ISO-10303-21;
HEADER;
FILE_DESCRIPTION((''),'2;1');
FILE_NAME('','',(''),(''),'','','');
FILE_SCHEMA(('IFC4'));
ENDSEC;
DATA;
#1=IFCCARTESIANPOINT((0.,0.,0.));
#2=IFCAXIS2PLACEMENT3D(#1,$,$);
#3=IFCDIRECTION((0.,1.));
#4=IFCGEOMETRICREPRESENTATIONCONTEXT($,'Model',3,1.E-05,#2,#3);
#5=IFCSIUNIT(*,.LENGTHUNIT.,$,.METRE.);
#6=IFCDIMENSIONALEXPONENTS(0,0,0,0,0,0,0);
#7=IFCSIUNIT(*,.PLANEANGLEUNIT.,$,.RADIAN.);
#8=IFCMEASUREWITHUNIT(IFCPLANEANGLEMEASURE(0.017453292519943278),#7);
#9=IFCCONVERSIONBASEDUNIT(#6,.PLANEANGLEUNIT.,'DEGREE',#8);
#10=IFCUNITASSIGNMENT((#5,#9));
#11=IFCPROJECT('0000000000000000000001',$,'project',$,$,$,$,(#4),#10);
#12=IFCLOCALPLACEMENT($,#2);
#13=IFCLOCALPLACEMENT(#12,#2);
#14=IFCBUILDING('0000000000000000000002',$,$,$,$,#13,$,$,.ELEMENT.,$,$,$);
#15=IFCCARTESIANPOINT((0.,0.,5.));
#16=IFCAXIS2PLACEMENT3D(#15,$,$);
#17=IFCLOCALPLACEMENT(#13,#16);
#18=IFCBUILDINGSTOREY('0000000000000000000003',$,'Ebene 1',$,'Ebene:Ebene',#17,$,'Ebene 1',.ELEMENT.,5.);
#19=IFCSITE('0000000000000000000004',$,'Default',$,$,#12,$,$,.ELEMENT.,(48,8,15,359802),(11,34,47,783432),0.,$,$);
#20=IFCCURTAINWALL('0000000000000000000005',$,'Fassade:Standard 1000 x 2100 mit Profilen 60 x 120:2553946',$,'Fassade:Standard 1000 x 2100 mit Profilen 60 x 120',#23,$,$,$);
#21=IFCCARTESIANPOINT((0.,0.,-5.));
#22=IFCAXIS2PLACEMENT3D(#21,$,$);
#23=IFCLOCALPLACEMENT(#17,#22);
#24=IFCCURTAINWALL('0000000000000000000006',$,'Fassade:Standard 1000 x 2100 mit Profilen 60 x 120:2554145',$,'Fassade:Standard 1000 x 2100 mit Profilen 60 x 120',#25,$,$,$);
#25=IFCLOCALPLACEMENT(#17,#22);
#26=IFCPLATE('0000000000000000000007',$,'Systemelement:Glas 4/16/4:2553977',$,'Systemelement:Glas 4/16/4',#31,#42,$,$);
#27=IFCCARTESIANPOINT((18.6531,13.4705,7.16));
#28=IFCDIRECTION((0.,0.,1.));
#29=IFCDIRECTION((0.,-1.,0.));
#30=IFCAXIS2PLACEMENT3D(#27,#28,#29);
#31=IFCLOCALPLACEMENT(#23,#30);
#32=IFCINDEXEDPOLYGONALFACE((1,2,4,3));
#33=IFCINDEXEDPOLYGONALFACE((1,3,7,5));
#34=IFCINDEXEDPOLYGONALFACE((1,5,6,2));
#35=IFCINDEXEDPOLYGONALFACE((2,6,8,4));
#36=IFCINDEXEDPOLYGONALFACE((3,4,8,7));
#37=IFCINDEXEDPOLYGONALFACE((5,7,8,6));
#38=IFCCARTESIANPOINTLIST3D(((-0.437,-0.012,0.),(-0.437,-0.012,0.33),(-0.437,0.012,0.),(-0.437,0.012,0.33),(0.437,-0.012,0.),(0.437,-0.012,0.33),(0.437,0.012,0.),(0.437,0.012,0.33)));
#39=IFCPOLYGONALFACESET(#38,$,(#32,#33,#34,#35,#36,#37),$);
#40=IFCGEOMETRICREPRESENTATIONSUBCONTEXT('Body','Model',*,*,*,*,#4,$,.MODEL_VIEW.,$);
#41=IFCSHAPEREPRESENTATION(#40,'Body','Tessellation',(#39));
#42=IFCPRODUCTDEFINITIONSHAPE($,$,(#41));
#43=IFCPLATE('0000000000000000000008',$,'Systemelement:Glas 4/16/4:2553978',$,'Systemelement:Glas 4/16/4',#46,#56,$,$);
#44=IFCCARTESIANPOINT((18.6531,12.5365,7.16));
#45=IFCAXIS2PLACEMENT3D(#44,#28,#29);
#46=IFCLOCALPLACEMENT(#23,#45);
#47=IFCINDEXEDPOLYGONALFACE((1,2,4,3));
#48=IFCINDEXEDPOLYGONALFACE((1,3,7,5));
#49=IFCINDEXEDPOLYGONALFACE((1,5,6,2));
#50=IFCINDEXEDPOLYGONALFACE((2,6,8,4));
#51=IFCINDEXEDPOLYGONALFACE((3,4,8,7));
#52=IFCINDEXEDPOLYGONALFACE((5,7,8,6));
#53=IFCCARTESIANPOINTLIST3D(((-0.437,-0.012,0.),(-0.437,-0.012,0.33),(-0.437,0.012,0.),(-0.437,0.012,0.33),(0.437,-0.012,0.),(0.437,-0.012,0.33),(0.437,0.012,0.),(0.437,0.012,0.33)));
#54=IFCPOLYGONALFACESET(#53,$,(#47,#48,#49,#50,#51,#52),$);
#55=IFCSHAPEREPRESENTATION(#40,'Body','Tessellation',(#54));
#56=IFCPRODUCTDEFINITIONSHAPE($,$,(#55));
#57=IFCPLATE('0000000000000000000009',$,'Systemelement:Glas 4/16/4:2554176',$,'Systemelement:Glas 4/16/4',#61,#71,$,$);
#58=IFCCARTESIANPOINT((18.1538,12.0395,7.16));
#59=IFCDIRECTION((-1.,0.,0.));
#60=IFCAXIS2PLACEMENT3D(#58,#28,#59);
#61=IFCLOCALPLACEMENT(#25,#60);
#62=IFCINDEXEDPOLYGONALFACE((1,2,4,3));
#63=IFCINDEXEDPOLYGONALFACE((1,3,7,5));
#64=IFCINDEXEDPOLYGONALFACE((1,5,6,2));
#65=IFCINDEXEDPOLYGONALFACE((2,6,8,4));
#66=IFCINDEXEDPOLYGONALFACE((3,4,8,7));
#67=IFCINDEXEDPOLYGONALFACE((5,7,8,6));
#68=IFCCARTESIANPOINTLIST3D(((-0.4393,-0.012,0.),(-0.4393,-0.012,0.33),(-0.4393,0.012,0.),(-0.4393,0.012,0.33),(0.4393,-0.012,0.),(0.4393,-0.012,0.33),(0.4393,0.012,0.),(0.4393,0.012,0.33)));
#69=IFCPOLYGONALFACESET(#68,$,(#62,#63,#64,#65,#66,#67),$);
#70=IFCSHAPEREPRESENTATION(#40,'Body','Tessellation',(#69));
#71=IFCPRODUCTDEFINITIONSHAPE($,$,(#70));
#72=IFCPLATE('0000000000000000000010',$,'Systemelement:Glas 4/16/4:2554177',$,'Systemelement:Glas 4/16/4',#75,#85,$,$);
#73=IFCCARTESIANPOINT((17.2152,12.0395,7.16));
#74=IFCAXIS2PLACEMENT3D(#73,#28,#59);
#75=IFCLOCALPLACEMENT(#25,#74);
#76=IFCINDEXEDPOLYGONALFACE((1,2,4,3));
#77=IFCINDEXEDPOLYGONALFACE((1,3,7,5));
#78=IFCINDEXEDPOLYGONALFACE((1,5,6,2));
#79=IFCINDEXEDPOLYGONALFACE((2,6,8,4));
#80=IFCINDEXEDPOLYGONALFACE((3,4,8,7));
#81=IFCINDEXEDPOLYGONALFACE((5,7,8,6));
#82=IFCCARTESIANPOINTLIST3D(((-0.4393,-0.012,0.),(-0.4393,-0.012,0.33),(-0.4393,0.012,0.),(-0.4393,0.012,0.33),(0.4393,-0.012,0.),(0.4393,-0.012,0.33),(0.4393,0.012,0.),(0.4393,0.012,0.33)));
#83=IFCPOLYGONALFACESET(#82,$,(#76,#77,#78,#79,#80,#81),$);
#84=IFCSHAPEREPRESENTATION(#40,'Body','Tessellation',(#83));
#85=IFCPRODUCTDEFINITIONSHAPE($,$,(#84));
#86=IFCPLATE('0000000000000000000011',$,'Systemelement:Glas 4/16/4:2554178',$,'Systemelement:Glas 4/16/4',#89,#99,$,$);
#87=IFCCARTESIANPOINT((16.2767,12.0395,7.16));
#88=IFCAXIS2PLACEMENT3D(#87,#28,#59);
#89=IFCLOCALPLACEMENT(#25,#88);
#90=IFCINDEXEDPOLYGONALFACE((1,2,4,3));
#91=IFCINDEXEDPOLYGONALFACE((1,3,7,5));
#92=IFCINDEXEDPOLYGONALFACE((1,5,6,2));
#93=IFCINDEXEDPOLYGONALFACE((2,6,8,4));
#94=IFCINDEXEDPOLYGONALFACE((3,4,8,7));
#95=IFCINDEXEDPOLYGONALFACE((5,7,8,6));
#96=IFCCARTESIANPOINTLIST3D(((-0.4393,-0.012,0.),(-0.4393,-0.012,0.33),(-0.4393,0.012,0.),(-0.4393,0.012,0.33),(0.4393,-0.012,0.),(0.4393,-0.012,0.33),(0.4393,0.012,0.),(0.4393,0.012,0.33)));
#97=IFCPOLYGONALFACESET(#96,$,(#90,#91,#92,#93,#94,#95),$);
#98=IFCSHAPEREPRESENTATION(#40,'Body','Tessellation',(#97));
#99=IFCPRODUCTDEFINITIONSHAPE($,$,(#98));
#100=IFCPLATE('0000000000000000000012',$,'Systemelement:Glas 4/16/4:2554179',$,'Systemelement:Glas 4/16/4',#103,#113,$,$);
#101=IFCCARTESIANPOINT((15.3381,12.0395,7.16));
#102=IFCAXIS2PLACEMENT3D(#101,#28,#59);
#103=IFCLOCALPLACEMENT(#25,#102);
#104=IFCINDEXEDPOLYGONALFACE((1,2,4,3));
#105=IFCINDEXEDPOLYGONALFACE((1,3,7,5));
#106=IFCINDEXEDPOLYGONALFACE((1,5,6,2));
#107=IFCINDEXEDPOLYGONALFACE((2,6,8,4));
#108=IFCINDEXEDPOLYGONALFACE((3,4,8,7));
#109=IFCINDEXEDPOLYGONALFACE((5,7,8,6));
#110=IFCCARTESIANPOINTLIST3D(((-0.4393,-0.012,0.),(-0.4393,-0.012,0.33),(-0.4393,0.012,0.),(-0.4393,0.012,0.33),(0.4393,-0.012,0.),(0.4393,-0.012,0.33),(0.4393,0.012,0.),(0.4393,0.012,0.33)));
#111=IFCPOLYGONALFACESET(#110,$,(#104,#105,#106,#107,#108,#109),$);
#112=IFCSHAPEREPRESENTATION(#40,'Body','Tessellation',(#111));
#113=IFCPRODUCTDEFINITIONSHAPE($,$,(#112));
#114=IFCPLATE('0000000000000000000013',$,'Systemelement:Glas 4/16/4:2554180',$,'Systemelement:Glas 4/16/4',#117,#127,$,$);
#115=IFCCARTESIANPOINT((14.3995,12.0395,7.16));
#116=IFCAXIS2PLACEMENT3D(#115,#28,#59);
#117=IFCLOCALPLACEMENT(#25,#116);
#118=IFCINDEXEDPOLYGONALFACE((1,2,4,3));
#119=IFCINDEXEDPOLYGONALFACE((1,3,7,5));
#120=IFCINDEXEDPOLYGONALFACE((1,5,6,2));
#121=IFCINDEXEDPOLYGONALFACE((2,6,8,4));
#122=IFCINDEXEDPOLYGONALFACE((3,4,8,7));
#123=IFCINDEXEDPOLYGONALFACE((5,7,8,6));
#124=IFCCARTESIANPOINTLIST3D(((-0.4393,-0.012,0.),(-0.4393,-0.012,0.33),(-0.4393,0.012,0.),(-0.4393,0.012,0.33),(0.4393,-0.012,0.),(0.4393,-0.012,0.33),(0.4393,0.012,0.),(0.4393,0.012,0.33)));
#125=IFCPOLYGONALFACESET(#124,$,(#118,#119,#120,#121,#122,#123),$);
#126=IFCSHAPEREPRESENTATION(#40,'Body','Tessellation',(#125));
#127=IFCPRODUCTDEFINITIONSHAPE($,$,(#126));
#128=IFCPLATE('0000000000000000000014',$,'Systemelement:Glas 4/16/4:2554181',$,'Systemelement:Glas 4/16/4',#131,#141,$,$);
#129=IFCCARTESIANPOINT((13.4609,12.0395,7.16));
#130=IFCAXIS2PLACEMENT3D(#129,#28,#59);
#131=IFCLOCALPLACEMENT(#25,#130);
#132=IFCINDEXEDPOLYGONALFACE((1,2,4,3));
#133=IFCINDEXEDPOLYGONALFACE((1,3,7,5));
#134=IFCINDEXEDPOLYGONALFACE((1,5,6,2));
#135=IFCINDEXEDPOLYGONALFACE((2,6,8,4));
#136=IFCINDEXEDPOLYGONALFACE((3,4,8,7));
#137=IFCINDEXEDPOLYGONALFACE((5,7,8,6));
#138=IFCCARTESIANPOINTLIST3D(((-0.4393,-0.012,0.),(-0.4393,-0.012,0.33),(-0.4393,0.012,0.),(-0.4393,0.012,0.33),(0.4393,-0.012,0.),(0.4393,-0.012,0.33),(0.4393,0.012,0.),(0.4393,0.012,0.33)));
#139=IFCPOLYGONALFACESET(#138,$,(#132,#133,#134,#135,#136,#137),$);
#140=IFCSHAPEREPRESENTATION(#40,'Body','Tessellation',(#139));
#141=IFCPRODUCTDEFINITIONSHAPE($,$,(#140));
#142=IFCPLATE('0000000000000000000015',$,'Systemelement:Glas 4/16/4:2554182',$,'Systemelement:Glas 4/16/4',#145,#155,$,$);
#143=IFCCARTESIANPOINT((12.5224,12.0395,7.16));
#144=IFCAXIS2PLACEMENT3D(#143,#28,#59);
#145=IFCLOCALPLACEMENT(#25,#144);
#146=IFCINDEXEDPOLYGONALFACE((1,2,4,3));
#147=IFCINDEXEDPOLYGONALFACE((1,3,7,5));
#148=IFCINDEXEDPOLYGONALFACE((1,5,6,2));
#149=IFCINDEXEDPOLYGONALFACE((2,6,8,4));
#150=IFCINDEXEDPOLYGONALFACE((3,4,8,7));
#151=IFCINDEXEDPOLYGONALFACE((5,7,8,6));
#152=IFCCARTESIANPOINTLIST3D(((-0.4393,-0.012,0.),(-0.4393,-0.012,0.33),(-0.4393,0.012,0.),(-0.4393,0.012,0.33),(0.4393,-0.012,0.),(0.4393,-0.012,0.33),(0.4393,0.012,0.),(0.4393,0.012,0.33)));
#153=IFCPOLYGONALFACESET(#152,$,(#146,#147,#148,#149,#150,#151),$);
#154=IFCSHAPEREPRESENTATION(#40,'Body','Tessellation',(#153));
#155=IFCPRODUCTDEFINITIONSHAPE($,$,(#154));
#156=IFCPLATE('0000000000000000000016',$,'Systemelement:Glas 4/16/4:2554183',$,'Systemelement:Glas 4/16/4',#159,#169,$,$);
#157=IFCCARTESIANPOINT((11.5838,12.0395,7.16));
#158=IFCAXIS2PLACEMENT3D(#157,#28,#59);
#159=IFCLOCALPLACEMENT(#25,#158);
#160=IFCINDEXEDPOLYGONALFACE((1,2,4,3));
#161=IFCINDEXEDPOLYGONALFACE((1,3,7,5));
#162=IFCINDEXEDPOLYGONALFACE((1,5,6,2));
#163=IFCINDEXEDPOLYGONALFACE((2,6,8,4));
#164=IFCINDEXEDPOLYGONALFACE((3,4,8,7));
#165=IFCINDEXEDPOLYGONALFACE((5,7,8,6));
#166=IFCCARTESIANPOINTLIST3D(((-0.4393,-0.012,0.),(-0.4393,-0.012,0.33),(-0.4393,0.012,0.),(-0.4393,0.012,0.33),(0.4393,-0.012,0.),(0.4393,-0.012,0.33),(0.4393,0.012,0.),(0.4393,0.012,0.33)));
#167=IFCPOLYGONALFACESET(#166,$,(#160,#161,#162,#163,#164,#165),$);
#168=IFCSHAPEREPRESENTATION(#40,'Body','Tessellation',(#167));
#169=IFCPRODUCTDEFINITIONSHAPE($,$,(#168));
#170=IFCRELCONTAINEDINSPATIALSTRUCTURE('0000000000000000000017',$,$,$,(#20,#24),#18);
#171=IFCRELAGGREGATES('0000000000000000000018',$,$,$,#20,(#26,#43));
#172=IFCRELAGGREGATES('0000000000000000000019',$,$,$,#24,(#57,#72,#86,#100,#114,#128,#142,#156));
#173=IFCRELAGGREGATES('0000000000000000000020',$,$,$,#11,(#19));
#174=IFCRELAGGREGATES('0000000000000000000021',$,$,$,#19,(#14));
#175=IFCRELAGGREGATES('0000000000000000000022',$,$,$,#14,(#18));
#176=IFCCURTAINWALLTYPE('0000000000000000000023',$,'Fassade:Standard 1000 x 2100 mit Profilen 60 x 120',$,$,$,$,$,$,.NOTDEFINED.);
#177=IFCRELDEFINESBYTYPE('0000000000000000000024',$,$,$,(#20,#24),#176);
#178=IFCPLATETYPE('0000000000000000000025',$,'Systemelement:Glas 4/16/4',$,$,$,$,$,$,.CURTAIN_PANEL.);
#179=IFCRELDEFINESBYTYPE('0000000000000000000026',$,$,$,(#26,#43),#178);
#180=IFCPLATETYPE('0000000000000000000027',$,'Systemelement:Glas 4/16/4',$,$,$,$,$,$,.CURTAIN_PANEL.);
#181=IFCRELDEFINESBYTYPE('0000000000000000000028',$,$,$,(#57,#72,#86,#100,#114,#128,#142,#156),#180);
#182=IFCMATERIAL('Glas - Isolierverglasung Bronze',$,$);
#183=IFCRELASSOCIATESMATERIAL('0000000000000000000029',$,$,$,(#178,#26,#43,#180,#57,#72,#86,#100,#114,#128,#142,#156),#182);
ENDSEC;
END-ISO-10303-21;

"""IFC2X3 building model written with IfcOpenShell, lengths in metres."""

from ifc_helpers import new_model, entity, si_unit, converted_unit, direction, frame, origin, origin_2d_with_axis, place, context, subcontext, project, spatial, rectangle, extrude, source, transform, mapped, material, type_object, type_shapes, element, aggregate, save


model = new_model("IFC2X3")

# Units and contexts
model_context = context("Model", 3, precision=1e-05, world=origin(), true_north=direction((0.0, 1.0)))
body_context = subcontext(model_context, "Body", "Model", "MODEL_VIEW")
ifc_project = project(units=[si_unit("LENGTHUNIT", "METRE"), converted_unit("PLANEANGLEUNIT", "DEGREE", entity("IfcPlaneAngleMeasure", 0.017453292519943278), si_unit("PLANEANGLEUNIT", "RADIAN"), dimensions=[0, 0, 0, 0, 0, 0, 0])], contexts=[model_context])

# Site, building, storey
site_placement = place(None, origin())
site = spatial("IfcSite", under=ifc_project, at=site_placement, Name="Default", CompositionType="ELEMENT", RefLatitude=(48, 8, 15, 359802), RefLongitude=(11, 34, 47, 783432), RefElevation=0.0)
building_placement = place(site_placement, origin())
building = spatial("IfcBuilding", under=site, at=building_placement, CompositionType="ELEMENT")
storey_placement = place(building_placement, frame((0.0, 0.0, 5.0)))
storey = spatial("IfcBuildingStorey", under=building, at=storey_placement, Name="Ebene 1", ObjectType="Ebene:Ebene", LongName="Ebene 1", CompositionType="ELEMENT", Elevation=5.0)

# Curtain wall
curtain_wall_type = type_object("IfcCurtainWallType", Name="Fassade:Standard 1000 x 2100 mit Profilen 60 x 120", PredefinedType="NOTDEFINED")
curtain_wall_1_placement = place(storey_placement, frame((0.0, 0.0, -5.0)))
curtain_wall_1 = element("IfcCurtainWall", 1, at=curtain_wall_1_placement, inside=storey, type_object=curtain_wall_type, Name="Fassade:Standard 1000 x 2100 mit Profilen 60 x 120:2553946", ObjectType="Fassade:Standard 1000 x 2100 mit Profilen 60 x 120")

# Curtain wall
curtain_wall_2_placement = place(storey_placement, frame((0.0, 0.0, -5.0)))
curtain_wall_2 = element("IfcCurtainWall", 2, at=curtain_wall_2_placement, inside=storey, type_object=curtain_wall_type, Name="Fassade:Standard 1000 x 2100 mit Profilen 60 x 120:2554145", ObjectType="Fassade:Standard 1000 x 2100 mit Profilen 60 x 120")

# Plates
ifc_material_1 = material(Name="Glas - Isolierverglasung Bronze")
plate_type_1 = type_object("IfcPlateType", Name="Systemelement:Glas 4/16/4", PredefinedType="CURTAIN_PANEL", material=ifc_material_1)
shared_shape_1 = source(origin(), body_context, "Body", "SweptSolid", [
    extrude(rectangle(XDim=0.024, YDim=0.874, at=origin_2d_with_axis()), frame((0.0, 0.0, 0.0), z_axis=(0.0, 0.0, 1.0), x_axis=(0.0, 1.0, 0.0)), (0.0, 0.0, 1.0), 0.33),
])
type_shapes(plate_type_1, [shared_shape_1])
plate_1_placement = place(curtain_wall_1_placement, frame((18.6531, 13.4705, 7.16), z_axis=(0.0, 0.0, 1.0), x_axis=(0.0, -1.0, 0.0)))
plate_1 = element("IfcPlate", 3, at=plate_1_placement, type_object=plate_type_1, material=ifc_material_1, Name="Systemelement:Glas 4/16/4:2553977", ObjectType="Systemelement:Glas 4/16/4", context=body_context, shape_type="MappedRepresentation", body=[
    mapped(shared_shape_1, transform((0.0, 0.0, 0.0), scale=1.0)),
])
plate_2_placement = place(curtain_wall_1_placement, frame((18.6531, 12.5365, 7.16), z_axis=(0.0, 0.0, 1.0), x_axis=(0.0, -1.0, 0.0)))
plate_2 = element("IfcPlate", 4, at=plate_2_placement, type_object=plate_type_1, material=ifc_material_1, Name="Systemelement:Glas 4/16/4:2553978", ObjectType="Systemelement:Glas 4/16/4", context=body_context, shape_type="MappedRepresentation", body=[
    mapped(shared_shape_1, transform((0.0, 0.0, 0.0), scale=1.0)),
])
aggregate(curtain_wall_1, [plate_1, plate_2])
plate_type_2 = type_object("IfcPlateType", Name="Systemelement:Glas 4/16/4", PredefinedType="CURTAIN_PANEL", material=ifc_material_1)
shared_shape_2 = source(origin(), body_context, "Body", "SweptSolid", [
    extrude(rectangle(XDim=0.024, YDim=0.8786, at=origin_2d_with_axis()), frame((0.0, 0.0, 0.0), z_axis=(0.0, 0.0, 1.0), x_axis=(0.0, 1.0, 0.0)), (0.0, 0.0, 1.0), 0.33),
])
type_shapes(plate_type_2, [shared_shape_2])
plate_3_placement = place(curtain_wall_2_placement, frame((18.1538, 12.0395, 7.16), z_axis=(0.0, 0.0, 1.0), x_axis=(-1.0, 0.0, 0.0)))
plate_3 = element("IfcPlate", 5, at=plate_3_placement, type_object=plate_type_2, material=ifc_material_1, Name="Systemelement:Glas 4/16/4:2554176", ObjectType="Systemelement:Glas 4/16/4", context=body_context, shape_type="MappedRepresentation", body=[
    mapped(shared_shape_2, transform((0.0, 0.0, 0.0), scale=1.0)),
])
plate_4_placement = place(curtain_wall_2_placement, frame((17.2152, 12.0395, 7.16), z_axis=(0.0, 0.0, 1.0), x_axis=(-1.0, 0.0, 0.0)))
plate_4 = element("IfcPlate", 6, at=plate_4_placement, type_object=plate_type_2, material=ifc_material_1, Name="Systemelement:Glas 4/16/4:2554177", ObjectType="Systemelement:Glas 4/16/4", context=body_context, shape_type="MappedRepresentation", body=[
    mapped(shared_shape_2, transform((0.0, 0.0, 0.0), scale=1.0)),
])
plate_5_placement = place(curtain_wall_2_placement, frame((16.2767, 12.0395, 7.16), z_axis=(0.0, 0.0, 1.0), x_axis=(-1.0, 0.0, 0.0)))
plate_5 = element("IfcPlate", 7, at=plate_5_placement, type_object=plate_type_2, material=ifc_material_1, Name="Systemelement:Glas 4/16/4:2554178", ObjectType="Systemelement:Glas 4/16/4", context=body_context, shape_type="MappedRepresentation", body=[
    mapped(shared_shape_2, transform((0.0, 0.0, 0.0), scale=1.0)),
])
plate_6_placement = place(curtain_wall_2_placement, frame((15.3381, 12.0395, 7.16), z_axis=(0.0, 0.0, 1.0), x_axis=(-1.0, 0.0, 0.0)))
plate_6 = element("IfcPlate", 8, at=plate_6_placement, type_object=plate_type_2, material=ifc_material_1, Name="Systemelement:Glas 4/16/4:2554179", ObjectType="Systemelement:Glas 4/16/4", context=body_context, shape_type="MappedRepresentation", body=[
    mapped(shared_shape_2, transform((0.0, 0.0, 0.0), scale=1.0)),
])
plate_7_placement = place(curtain_wall_2_placement, frame((14.3995, 12.0395, 7.16), z_axis=(0.0, 0.0, 1.0), x_axis=(-1.0, 0.0, 0.0)))
plate_7 = element("IfcPlate", 9, at=plate_7_placement, type_object=plate_type_2, material=ifc_material_1, Name="Systemelement:Glas 4/16/4:2554180", ObjectType="Systemelement:Glas 4/16/4", context=body_context, shape_type="MappedRepresentation", body=[
    mapped(shared_shape_2, transform((0.0, 0.0, 0.0), scale=1.0)),
])
plate_8_placement = place(curtain_wall_2_placement, frame((13.4609, 12.0395, 7.16), z_axis=(0.0, 0.0, 1.0), x_axis=(-1.0, 0.0, 0.0)))
plate_8 = element("IfcPlate", 10, at=plate_8_placement, type_object=plate_type_2, material=ifc_material_1, Name="Systemelement:Glas 4/16/4:2554181", ObjectType="Systemelement:Glas 4/16/4", context=body_context, shape_type="MappedRepresentation", body=[
    mapped(shared_shape_2, transform((0.0, 0.0, 0.0), scale=1.0)),
])
plate_9_placement = place(curtain_wall_2_placement, frame((12.5224, 12.0395, 7.16), z_axis=(0.0, 0.0, 1.0), x_axis=(-1.0, 0.0, 0.0)))
plate_9 = element("IfcPlate", 11, at=plate_9_placement, type_object=plate_type_2, material=ifc_material_1, Name="Systemelement:Glas 4/16/4:2554182", ObjectType="Systemelement:Glas 4/16/4", context=body_context, shape_type="MappedRepresentation", body=[
    mapped(shared_shape_2, transform((0.0, 0.0, 0.0), scale=1.0)),
])
plate_10_placement = place(curtain_wall_2_placement, frame((11.5838, 12.0395, 7.16), z_axis=(0.0, 0.0, 1.0), x_axis=(-1.0, 0.0, 0.0)))
plate_10 = element("IfcPlate", 12, at=plate_10_placement, type_object=plate_type_2, material=ifc_material_1, Name="Systemelement:Glas 4/16/4:2554183", ObjectType="Systemelement:Glas 4/16/4", context=body_context, shape_type="MappedRepresentation", body=[
    mapped(shared_shape_2, transform((0.0, 0.0, 0.0), scale=1.0)),
])
aggregate(curtain_wall_2, [plate_3, plate_4, plate_5, plate_6, plate_7, plate_8, plate_9, plate_10])

save(model, "model.ifc")
